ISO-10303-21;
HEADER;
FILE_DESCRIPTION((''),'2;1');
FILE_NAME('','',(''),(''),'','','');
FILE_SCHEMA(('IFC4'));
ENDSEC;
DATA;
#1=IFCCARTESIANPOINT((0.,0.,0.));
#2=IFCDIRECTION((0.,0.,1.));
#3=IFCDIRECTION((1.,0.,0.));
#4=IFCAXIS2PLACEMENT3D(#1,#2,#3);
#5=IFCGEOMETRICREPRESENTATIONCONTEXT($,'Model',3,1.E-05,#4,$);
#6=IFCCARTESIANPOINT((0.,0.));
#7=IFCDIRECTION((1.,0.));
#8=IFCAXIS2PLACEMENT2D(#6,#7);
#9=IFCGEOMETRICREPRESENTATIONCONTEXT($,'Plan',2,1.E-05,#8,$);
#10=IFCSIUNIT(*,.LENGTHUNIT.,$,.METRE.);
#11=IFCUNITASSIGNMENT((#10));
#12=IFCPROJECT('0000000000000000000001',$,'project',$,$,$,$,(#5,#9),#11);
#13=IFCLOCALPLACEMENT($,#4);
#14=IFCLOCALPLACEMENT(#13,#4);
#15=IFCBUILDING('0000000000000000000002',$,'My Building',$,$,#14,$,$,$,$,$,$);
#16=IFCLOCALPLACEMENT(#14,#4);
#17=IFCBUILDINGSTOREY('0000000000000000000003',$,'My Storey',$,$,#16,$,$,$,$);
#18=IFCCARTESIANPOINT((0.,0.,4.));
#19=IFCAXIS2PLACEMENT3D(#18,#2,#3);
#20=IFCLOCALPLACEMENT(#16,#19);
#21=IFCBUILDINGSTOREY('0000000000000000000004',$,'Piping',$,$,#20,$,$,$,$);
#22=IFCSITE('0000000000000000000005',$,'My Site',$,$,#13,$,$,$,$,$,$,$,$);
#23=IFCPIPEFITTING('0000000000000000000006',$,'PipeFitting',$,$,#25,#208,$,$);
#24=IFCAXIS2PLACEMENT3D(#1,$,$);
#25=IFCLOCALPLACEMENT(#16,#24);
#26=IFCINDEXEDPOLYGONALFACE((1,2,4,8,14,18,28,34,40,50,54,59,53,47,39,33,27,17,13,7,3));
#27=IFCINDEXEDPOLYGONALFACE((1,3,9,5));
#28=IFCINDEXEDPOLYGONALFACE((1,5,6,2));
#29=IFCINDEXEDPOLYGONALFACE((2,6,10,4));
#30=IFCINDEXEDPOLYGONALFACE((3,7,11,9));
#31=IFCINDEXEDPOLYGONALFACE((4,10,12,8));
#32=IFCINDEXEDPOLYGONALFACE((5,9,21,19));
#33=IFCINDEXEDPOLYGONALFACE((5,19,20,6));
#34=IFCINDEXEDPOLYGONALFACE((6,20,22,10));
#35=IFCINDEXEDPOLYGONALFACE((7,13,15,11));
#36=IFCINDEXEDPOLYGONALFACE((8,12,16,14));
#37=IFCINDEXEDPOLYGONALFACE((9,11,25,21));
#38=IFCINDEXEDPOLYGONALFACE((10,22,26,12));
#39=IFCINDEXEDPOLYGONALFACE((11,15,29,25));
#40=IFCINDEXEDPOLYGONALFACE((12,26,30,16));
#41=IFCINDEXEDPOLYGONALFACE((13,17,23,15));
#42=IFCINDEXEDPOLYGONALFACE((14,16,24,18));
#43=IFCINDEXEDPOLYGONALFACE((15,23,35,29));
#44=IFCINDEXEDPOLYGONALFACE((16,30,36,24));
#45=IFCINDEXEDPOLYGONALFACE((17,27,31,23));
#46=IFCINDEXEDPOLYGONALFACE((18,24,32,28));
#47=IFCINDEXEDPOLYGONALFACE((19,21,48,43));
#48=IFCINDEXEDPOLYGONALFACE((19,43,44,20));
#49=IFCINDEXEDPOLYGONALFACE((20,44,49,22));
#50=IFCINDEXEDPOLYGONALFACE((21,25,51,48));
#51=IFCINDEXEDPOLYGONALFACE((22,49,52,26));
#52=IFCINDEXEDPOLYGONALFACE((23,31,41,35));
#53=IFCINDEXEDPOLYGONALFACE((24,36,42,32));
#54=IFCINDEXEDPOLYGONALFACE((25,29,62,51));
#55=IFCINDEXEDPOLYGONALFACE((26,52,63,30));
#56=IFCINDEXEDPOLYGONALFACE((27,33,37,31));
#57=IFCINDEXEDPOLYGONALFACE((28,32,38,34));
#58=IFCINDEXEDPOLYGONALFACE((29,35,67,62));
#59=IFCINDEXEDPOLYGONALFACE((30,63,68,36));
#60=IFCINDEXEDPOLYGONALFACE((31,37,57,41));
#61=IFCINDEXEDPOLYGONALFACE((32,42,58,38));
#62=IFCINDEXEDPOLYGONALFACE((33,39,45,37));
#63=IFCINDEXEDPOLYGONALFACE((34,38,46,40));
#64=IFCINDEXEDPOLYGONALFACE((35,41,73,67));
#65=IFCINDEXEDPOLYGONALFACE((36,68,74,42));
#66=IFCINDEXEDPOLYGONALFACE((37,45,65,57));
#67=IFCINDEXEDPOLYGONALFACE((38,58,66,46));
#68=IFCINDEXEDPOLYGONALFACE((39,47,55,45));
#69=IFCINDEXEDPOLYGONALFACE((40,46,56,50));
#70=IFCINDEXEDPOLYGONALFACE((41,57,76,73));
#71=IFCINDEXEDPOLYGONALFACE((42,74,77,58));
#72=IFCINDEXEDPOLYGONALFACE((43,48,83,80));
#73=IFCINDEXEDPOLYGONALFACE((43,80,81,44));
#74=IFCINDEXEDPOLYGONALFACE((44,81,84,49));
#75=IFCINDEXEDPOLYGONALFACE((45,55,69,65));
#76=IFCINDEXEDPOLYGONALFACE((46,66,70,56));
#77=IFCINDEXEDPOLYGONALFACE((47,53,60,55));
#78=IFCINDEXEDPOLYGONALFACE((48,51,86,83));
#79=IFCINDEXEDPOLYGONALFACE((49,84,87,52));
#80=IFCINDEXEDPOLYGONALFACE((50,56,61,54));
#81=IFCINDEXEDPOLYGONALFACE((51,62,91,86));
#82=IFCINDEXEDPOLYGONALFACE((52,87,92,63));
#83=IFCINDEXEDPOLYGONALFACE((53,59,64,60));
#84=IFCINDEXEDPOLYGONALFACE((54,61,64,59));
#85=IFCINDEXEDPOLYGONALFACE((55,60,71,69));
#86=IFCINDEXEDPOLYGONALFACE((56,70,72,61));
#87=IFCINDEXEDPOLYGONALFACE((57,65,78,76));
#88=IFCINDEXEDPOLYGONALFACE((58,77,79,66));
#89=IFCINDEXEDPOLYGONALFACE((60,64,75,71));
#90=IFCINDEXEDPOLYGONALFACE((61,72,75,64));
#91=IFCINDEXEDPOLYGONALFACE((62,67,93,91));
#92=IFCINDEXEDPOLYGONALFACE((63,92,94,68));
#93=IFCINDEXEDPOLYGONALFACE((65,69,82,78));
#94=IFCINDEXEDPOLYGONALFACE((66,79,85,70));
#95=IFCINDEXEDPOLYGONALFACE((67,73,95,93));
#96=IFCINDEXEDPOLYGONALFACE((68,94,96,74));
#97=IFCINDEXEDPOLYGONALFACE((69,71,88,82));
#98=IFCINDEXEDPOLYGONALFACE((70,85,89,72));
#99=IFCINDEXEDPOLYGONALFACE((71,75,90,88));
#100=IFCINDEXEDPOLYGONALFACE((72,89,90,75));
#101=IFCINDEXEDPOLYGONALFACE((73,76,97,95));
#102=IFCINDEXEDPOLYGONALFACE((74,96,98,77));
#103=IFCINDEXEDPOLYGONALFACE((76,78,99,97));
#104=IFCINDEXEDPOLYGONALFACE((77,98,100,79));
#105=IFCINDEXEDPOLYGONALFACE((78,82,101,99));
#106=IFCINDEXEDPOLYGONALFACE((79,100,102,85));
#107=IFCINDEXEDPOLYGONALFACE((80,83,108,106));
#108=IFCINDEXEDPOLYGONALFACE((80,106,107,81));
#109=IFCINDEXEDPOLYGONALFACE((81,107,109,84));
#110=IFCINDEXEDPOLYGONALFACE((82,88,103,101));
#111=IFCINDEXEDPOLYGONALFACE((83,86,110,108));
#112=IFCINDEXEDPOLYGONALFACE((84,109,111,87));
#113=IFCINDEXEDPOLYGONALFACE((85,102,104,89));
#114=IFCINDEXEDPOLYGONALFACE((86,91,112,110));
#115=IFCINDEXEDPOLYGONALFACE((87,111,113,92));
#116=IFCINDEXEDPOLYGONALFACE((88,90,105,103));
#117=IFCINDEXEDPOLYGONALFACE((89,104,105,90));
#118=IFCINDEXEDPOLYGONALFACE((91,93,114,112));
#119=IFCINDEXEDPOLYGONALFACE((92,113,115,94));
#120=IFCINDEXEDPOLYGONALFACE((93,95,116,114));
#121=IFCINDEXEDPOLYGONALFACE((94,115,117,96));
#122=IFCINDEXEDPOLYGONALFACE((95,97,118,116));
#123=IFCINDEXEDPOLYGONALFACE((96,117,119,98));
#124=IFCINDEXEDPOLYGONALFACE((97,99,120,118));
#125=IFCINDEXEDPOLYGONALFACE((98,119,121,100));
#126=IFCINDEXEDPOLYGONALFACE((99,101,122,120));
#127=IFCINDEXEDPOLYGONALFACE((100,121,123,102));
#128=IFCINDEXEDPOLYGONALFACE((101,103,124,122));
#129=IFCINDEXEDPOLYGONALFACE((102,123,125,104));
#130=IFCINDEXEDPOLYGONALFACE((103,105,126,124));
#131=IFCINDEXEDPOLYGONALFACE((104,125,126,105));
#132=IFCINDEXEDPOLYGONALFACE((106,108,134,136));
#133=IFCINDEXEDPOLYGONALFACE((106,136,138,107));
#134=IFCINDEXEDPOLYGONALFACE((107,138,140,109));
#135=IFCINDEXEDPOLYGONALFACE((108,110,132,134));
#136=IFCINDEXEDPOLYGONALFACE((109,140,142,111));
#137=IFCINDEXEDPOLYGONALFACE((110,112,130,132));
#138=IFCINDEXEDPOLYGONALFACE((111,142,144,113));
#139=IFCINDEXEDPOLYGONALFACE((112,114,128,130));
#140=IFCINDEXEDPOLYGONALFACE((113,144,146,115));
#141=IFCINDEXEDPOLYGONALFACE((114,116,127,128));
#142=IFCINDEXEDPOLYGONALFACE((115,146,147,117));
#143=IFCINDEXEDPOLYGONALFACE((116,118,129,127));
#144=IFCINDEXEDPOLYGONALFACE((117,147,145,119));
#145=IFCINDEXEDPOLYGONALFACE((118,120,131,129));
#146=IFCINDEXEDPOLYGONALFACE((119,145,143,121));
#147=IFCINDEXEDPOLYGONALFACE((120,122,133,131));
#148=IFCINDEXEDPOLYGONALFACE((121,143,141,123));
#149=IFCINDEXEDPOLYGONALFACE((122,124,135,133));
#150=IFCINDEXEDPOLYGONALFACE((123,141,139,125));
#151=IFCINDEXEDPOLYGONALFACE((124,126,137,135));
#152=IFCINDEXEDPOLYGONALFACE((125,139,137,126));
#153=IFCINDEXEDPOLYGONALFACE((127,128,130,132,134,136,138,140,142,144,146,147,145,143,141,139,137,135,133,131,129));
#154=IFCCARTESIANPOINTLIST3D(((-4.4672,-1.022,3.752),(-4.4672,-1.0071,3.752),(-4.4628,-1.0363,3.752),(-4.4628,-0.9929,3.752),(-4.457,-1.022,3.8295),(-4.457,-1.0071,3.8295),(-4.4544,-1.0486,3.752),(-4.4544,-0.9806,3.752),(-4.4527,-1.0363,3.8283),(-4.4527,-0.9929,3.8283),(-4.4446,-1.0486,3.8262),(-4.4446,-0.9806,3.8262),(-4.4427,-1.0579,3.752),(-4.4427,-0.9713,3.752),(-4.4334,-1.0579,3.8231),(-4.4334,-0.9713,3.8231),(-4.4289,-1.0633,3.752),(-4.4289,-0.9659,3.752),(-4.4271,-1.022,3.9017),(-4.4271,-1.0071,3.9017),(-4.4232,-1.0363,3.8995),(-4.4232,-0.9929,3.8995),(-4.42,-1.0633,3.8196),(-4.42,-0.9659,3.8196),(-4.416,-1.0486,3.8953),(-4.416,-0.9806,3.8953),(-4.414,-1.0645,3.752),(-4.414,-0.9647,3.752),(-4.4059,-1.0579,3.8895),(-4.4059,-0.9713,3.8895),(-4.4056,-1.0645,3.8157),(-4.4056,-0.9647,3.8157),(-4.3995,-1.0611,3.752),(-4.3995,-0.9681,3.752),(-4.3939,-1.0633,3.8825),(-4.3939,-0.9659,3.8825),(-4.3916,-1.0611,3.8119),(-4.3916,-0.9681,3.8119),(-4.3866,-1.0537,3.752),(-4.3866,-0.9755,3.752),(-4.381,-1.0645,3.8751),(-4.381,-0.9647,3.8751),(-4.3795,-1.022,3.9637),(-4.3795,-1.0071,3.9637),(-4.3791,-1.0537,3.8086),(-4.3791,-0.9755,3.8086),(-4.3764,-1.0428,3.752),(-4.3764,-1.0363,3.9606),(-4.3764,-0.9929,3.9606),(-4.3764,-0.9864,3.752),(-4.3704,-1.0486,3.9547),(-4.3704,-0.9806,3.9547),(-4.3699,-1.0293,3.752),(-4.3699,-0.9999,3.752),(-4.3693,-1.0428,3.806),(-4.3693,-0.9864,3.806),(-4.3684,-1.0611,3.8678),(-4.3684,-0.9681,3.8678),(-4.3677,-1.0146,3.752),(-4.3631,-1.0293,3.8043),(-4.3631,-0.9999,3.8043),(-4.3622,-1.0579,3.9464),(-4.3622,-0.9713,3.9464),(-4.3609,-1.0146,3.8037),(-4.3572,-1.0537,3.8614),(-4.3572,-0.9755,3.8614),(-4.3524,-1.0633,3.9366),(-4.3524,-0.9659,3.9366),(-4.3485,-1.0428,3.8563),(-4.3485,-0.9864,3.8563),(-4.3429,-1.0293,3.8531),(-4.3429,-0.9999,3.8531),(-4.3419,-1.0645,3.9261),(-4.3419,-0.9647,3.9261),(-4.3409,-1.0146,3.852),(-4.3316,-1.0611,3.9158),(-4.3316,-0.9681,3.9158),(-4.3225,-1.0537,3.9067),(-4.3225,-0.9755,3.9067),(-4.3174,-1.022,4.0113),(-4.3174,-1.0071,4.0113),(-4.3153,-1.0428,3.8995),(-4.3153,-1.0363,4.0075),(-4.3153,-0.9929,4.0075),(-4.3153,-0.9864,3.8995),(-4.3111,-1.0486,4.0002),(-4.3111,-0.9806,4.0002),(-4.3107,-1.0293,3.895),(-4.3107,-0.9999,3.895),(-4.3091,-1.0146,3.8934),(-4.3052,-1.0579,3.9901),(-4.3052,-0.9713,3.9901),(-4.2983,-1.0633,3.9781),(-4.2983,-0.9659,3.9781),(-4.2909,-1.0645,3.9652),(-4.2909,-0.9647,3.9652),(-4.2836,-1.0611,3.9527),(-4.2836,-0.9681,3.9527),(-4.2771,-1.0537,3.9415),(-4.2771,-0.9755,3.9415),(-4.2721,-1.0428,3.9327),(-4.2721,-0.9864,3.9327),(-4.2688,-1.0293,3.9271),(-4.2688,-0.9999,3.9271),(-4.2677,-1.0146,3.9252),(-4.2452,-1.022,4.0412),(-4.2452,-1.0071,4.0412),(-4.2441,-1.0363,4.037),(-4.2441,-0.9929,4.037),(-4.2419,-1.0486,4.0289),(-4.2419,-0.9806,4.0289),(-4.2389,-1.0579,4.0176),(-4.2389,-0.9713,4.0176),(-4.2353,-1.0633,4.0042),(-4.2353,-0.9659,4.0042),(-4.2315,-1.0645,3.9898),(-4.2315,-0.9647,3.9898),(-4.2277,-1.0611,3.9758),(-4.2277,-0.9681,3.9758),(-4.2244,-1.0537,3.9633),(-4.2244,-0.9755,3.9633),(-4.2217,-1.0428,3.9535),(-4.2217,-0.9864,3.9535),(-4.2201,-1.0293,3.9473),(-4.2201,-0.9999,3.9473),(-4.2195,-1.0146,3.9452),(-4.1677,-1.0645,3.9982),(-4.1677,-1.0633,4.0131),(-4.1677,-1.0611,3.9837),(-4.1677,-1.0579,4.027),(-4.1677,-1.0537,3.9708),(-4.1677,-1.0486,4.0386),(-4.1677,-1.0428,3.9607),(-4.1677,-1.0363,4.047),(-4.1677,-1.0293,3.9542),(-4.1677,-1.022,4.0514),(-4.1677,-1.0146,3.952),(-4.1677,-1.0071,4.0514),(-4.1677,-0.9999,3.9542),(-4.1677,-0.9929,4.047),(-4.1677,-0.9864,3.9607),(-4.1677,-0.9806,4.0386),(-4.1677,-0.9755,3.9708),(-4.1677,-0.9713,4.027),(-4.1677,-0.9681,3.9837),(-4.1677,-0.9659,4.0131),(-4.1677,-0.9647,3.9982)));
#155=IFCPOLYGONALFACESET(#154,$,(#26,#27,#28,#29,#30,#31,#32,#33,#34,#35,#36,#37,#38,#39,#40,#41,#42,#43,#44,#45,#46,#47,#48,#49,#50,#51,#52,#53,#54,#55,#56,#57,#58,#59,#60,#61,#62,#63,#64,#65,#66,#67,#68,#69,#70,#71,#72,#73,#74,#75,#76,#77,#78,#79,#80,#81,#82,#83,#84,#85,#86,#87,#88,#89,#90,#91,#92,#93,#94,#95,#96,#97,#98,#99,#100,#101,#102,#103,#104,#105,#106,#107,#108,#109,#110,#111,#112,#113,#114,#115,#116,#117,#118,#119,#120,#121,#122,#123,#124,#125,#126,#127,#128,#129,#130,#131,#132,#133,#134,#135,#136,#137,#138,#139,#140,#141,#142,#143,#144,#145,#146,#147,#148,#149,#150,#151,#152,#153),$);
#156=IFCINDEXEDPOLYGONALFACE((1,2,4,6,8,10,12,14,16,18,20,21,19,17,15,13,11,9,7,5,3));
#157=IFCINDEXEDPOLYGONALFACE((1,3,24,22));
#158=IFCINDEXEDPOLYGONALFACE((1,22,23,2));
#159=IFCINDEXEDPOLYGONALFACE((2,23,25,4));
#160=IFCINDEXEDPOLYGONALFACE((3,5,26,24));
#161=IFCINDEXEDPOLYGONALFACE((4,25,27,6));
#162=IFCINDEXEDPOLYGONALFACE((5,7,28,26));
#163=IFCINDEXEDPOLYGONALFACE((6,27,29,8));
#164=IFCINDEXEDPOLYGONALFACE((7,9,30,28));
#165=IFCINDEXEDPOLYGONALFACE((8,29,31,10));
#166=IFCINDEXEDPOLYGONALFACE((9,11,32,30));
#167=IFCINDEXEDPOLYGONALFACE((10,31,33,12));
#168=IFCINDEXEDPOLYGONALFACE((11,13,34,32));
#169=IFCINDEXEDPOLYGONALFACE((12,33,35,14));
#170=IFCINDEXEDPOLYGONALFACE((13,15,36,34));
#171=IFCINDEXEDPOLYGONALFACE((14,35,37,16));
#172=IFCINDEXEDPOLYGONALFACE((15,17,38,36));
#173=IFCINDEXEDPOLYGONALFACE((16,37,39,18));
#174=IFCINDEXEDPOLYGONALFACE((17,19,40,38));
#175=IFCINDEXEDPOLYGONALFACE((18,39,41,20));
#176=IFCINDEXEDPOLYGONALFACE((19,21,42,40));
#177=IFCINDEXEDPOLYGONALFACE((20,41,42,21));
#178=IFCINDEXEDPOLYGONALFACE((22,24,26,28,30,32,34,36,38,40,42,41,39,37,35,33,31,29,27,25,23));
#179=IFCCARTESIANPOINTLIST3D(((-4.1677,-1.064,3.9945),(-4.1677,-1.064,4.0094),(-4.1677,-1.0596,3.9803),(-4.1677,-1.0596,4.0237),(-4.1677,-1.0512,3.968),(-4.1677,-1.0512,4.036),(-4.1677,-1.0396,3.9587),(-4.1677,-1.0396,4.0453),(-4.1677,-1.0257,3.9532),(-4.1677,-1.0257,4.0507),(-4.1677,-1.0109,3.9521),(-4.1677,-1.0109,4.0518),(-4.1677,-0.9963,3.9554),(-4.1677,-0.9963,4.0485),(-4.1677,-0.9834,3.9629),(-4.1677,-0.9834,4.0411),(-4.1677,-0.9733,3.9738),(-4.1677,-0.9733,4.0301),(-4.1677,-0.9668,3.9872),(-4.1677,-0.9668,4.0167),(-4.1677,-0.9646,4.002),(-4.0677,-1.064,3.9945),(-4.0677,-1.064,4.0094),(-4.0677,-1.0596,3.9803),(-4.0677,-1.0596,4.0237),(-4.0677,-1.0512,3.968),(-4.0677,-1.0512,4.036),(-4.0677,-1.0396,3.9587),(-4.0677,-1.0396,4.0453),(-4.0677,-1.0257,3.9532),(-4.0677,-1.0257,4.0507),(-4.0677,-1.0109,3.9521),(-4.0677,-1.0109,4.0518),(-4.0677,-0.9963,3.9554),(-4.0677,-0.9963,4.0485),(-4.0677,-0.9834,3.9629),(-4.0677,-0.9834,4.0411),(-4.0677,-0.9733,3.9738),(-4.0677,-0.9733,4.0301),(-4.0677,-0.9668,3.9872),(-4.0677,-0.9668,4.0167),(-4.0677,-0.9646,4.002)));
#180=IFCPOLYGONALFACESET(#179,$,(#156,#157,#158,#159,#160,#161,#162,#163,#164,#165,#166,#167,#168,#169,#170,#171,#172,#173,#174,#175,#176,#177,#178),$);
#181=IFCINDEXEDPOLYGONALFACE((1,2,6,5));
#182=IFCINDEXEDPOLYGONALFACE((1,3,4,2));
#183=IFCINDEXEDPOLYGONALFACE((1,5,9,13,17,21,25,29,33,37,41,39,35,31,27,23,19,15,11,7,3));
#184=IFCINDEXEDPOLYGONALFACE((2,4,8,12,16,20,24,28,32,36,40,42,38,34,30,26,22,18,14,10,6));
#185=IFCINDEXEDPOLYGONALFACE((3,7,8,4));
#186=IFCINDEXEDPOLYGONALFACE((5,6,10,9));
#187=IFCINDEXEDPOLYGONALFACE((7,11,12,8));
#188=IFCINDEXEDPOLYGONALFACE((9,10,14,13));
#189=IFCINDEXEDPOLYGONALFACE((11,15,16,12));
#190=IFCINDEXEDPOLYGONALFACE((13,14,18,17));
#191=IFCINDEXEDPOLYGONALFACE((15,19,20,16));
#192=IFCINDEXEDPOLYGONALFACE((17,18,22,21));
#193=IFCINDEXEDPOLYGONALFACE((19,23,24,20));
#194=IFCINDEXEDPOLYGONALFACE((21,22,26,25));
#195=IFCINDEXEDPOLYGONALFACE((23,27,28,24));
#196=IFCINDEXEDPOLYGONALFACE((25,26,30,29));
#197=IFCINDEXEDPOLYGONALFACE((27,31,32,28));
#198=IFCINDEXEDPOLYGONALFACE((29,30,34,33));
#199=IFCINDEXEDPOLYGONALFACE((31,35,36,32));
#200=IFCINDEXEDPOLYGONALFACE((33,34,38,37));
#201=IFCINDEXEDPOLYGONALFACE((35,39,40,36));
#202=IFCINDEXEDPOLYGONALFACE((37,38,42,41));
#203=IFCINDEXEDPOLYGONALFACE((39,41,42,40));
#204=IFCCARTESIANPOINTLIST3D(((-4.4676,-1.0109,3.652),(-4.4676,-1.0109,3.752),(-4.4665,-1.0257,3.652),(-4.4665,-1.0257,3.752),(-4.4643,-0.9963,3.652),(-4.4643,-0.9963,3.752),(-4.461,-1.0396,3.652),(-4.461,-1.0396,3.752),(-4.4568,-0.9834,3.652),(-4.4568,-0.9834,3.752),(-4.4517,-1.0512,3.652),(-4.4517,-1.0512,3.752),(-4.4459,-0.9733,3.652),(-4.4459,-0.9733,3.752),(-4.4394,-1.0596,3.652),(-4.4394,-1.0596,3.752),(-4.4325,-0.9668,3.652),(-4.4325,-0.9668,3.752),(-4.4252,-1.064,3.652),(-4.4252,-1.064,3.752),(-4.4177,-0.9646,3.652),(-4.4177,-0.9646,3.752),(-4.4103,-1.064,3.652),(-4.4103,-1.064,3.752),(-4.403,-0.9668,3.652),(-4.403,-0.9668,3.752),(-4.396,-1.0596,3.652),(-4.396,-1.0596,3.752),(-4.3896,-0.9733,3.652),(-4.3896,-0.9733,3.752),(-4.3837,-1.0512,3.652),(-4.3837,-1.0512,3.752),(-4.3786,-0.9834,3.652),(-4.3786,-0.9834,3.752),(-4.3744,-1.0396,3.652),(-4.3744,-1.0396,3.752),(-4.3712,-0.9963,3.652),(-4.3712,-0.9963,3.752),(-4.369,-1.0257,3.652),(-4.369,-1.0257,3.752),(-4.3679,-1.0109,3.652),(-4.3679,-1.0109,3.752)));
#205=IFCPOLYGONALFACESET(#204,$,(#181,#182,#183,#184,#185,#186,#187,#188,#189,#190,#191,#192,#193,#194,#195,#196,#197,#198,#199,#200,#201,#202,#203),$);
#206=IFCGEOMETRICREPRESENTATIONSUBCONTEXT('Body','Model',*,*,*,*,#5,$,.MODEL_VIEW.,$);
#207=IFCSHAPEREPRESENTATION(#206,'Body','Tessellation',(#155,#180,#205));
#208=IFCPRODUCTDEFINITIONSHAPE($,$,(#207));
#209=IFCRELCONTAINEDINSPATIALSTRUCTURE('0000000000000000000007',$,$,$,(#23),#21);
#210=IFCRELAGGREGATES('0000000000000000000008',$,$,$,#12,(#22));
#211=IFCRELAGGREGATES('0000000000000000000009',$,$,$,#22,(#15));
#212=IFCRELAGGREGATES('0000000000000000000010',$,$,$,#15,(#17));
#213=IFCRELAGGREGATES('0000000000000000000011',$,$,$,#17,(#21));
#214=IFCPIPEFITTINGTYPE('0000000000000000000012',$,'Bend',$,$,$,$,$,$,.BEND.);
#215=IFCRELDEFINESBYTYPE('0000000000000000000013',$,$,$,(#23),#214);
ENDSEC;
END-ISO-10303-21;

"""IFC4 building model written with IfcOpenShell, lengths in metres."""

from ifc_helpers import new_model, entity, si_unit, frame, origin_with_axes, origin_2d_with_axis, place, context, subcontext, project, spatial, line, indexed_curve, circle, outline, extrude, source, transform, mapped, type_object, type_shapes, element, save


model = new_model("IFC4")

# Units and contexts
model_context = context("Model", 3, precision=1e-05, world=origin_with_axes())
plan_context = context("Plan", 2, precision=1e-05, world=origin_2d_with_axis())
body_context = subcontext(model_context, "Body", "Model", "MODEL_VIEW")
ifc_project = project(units=[si_unit("LENGTHUNIT", "METRE")], contexts=[model_context, plan_context])

# Site, building, storeys
site_placement = place(None, origin_with_axes())
site = spatial("IfcSite", under=ifc_project, at=site_placement, Name="My Site")
building_placement = place(site_placement, origin_with_axes())
building = spatial("IfcBuilding", under=site, at=building_placement, Name="My Building")
storey_1_placement = place(building_placement, origin_with_axes())
storey_1 = spatial("IfcBuildingStorey", under=building, at=storey_1_placement, Name="My Storey")
storey_2_placement = place(storey_1_placement, frame((0.0, 0.0, 4.0), z_axis=(0.0, 0.0, 1.0), x_axis=(1.0, 0.0, 0.0)))
storey_2 = spatial("IfcBuildingStorey", under=storey_1, at=storey_2_placement, Name="Piping")

# Shared definitions
pipe_fitting_type_1 = type_object("IfcPipeFittingType", Name="Bend", PredefinedType="BEND")
shared_shape = source(origin_with_axes(), body_context, "Body", "SolidModel", [
    entity("IfcSweptDiskSolid", entity("IfcIndexedPolyCurve", entity("IfcCartesianPointList3D", [[0.0, 0.0, -0.1], [0.0, -0.0732, -0.2768], [0.0, -0.25, -0.35]]), [entity("IfcArcIndex", [1, 2, 3])]), 0.05),
    extrude(circle(Radius=0.05), origin_with_axes(), (0.0, 0.0, -1.0), 0.1),
    extrude(circle(Radius=0.05), frame((0.0, -0.25, -0.35), z_axis=(0.0, -1.0, 0.0), x_axis=(1.0, 0.0, 0.0)), (0.0, 0.0, 1.0), 0.1),
])
type_shapes(pipe_fitting_type_1, [shared_shape])

# Pipe fitting, opening
pipe_fitting_1_placement = place(storey_2_placement, frame((-4.0677, -1.0146, 0.002), z_axis=(1.0, 0.0, 0.0), x_axis=(0.0, 1.0, 0.0)))
pipe_fitting_1 = element("IfcPipeFitting", 1, at=pipe_fitting_1_placement, inside=storey_2, type_object=pipe_fitting_type_1, Name="PipeFitting", context=body_context, shape_type="MappedRepresentation", body=[
    mapped(shared_shape, transform((0.0, 0.0, 0.0), x_axis=(1.0, 0.0, 0.0), y_axis=(0.0, 1.0, 0.0), z_axis=(0.0, 0.0, 1.0), scale=1.0)),
])
opening_1_placement = place(pipe_fitting_1_placement, frame((1.0146, -4.002, 4.0677), z_axis=(0.0, 1.0, 0.0), x_axis=(0.0, 0.0, 1.0)))
element("IfcOpeningElement", 2, at=opening_1_placement, cuts=pipe_fitting_1, PredefinedType="OPENING", context=body_context, shape_type="SweptSolid", body=[
    extrude(outline(indexed_curve([(0.0, 0.0), (0.5, 0.0), (0.5, 0.5), (0.0, 0.5)], segments=[line(1, 2, 3, 4, 1)])), origin_with_axes(), (0.0, 0.0, 1.0), 0.5),
])

save(model, "model.ifc")
